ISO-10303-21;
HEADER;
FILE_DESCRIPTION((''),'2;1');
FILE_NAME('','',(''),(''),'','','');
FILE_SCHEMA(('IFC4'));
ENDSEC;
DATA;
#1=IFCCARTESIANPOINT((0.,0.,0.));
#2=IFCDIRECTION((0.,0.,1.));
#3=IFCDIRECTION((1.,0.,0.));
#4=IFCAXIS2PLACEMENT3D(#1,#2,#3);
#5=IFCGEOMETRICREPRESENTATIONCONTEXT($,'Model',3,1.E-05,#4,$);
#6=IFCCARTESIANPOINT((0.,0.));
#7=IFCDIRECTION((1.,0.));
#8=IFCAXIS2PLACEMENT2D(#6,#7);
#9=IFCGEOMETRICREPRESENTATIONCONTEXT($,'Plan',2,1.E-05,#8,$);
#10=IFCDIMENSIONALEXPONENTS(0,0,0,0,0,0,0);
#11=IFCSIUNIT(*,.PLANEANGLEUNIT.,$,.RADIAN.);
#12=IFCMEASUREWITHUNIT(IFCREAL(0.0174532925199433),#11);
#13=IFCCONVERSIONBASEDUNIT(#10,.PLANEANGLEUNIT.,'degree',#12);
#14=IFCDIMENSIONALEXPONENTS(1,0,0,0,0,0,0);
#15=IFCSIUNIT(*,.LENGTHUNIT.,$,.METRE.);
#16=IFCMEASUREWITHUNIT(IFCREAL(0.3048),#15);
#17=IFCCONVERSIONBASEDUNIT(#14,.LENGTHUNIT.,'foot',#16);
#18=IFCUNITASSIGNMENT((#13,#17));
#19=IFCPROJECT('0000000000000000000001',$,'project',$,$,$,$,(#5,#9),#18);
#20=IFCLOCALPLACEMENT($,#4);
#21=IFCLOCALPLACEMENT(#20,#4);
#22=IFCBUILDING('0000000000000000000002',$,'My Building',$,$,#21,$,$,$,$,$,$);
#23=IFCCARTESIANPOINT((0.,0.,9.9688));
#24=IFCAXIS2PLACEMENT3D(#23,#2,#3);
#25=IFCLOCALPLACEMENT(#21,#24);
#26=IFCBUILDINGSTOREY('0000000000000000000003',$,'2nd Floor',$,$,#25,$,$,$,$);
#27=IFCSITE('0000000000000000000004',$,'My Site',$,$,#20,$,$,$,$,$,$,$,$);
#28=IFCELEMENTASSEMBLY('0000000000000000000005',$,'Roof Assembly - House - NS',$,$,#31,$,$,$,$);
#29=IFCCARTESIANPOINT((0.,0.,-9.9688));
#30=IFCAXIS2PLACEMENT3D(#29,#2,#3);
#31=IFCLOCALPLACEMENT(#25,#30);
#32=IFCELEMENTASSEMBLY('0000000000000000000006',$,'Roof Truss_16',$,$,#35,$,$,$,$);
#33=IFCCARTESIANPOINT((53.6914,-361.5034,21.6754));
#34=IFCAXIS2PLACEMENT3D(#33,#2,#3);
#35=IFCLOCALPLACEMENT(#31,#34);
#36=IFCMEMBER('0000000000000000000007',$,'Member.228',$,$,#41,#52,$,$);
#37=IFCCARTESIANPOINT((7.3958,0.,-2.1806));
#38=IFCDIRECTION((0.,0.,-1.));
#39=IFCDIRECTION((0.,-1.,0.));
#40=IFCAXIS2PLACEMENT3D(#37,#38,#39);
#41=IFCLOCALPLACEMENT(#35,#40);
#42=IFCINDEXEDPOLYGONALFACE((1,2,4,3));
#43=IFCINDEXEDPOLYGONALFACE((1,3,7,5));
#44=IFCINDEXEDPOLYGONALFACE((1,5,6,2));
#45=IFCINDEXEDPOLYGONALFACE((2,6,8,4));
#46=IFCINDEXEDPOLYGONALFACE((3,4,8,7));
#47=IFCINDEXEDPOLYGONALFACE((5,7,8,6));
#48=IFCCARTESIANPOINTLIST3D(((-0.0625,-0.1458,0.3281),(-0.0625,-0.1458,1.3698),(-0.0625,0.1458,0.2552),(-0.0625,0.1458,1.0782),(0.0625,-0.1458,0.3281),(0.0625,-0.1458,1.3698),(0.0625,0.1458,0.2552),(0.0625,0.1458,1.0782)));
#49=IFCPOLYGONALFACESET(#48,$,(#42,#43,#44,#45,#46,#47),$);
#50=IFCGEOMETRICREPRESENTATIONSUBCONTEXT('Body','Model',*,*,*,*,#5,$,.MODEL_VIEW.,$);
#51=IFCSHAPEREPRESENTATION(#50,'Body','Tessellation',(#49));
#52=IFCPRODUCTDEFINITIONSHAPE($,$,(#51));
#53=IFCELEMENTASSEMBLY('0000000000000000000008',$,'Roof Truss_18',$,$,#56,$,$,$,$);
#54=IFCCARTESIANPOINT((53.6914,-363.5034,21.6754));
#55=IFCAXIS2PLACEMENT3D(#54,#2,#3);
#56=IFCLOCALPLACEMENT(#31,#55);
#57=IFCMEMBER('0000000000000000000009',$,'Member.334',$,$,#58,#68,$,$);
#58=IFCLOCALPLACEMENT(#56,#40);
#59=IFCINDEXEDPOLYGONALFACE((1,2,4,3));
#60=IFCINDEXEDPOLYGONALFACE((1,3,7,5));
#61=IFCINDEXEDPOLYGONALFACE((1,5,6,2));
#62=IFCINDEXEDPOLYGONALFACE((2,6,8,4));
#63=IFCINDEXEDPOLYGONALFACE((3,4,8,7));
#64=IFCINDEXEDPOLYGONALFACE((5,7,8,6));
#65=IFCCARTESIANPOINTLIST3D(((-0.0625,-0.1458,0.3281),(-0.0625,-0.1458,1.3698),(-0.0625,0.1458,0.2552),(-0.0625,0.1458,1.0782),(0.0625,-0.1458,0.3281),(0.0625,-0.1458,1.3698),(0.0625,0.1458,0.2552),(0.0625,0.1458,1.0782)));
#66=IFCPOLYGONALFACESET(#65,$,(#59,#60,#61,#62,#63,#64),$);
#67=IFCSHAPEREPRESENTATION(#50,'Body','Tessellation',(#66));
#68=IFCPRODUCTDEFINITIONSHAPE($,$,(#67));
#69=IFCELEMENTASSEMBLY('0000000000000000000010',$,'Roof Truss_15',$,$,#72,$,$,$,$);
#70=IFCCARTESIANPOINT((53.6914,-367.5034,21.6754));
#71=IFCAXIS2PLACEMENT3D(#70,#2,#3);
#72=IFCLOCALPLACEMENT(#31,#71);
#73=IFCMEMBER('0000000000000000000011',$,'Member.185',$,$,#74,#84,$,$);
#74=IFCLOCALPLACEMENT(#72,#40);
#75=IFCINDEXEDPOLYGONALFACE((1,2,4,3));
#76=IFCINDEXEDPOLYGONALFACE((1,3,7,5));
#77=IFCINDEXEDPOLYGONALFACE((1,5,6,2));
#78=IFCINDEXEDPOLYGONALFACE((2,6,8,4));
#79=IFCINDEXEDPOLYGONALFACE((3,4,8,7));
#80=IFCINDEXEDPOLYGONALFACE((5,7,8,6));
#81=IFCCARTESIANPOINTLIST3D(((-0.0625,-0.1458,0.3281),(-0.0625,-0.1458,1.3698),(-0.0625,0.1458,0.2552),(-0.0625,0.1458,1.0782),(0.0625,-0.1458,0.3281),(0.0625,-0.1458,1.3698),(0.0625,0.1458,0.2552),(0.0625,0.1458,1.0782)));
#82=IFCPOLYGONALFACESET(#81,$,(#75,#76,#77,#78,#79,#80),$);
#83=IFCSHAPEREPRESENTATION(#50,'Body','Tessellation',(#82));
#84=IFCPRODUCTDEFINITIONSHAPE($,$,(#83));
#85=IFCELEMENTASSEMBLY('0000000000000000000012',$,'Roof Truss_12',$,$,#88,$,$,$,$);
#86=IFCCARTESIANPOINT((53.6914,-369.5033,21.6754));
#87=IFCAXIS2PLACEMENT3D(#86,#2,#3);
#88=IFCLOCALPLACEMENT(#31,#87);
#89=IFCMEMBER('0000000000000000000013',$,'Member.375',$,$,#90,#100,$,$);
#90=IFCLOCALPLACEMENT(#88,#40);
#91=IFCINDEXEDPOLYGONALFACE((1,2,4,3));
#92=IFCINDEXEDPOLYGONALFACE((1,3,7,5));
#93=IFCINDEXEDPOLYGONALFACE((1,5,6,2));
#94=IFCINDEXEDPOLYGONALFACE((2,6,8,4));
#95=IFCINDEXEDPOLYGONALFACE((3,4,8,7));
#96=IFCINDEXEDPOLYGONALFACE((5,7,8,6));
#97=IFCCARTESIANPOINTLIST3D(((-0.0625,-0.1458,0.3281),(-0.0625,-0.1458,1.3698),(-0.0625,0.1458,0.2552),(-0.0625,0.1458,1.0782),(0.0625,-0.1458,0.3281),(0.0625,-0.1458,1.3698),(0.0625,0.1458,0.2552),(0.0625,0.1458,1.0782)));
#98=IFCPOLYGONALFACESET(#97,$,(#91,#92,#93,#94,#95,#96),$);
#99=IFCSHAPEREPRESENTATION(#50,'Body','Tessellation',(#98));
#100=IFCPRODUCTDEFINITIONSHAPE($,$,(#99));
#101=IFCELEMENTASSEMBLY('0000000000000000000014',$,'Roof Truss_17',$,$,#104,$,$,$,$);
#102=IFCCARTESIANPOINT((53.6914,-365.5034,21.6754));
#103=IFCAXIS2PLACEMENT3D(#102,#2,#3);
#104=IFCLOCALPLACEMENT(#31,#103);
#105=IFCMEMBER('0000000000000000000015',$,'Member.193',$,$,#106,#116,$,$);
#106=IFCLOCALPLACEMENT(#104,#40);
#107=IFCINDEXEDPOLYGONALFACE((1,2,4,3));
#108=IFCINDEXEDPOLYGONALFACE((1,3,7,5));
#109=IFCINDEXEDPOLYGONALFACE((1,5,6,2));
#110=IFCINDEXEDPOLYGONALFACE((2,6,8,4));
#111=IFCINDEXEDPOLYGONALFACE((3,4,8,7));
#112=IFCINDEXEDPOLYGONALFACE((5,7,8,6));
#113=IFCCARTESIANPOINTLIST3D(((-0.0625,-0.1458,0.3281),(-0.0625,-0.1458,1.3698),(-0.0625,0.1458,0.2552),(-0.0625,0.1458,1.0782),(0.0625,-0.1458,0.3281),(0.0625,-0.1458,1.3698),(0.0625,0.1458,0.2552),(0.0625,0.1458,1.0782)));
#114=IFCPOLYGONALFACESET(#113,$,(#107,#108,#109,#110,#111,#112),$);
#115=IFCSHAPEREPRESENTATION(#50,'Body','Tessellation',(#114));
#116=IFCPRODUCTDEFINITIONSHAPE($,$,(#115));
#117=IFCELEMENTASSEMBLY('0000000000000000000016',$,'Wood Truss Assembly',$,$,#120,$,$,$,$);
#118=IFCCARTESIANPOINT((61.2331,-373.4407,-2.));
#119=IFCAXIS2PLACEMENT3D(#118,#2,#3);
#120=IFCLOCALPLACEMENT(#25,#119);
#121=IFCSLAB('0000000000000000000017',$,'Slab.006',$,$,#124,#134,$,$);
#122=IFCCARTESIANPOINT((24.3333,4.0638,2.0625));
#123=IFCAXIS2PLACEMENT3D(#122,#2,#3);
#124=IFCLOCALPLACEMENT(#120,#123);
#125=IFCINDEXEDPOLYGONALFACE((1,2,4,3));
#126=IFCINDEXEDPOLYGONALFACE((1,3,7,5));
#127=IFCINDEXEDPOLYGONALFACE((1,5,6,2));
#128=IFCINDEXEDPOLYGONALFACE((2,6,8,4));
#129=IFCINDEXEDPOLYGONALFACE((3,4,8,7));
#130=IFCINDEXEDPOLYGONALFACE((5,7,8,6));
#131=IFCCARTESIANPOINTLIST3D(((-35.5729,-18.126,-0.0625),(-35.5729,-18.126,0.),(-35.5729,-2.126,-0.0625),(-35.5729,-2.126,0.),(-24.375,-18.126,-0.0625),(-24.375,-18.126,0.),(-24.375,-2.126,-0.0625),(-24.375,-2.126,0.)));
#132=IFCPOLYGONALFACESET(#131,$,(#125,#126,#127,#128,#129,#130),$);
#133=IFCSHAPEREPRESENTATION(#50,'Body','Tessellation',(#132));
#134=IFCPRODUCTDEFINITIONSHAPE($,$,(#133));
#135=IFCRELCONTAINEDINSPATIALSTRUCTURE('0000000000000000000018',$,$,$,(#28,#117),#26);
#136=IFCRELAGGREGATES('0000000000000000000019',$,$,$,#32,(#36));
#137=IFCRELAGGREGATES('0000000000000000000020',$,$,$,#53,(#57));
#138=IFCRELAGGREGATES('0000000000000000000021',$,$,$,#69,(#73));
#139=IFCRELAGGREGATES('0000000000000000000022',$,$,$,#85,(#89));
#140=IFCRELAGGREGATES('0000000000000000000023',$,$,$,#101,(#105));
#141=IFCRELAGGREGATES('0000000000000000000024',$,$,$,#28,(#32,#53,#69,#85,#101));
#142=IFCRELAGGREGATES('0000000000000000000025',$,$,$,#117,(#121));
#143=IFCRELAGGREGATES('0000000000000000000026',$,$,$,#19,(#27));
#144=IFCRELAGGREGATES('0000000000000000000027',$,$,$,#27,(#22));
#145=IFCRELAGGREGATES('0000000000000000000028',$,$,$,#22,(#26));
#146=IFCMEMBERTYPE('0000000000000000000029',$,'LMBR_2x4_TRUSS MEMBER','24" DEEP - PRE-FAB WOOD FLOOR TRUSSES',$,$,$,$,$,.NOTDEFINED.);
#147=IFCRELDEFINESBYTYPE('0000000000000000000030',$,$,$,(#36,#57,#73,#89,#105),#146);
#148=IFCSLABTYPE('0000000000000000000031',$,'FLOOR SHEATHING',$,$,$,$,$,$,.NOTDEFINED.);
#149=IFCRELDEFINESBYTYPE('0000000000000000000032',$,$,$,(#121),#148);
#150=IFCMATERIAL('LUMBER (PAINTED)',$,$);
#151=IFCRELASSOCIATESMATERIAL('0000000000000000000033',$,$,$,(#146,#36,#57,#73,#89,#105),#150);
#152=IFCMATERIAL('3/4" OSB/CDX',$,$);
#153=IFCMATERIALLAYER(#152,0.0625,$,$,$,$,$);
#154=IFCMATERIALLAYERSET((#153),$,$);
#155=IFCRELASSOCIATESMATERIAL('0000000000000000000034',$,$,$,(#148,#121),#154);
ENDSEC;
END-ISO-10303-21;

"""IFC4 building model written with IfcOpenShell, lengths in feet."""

from ifc_helpers import new_model, entity, si_unit, converted_unit, frame, origin_with_axes, origin_2d_with_axis, place, context, subcontext, project, spatial, indexed_curve, outline, extrude, clip, halfspace, material, layer, layer_set, layer_usage, material_profile, profile_set, profile_usage, type_object, element, aggregate, save


model = new_model("IFC4")

# Units and contexts
model_context = context("Model", 3, precision=1e-05, world=origin_with_axes())
plan_context = context("Plan", 2, precision=1e-05, world=origin_2d_with_axis())
body_context = subcontext(model_context, "Body", "Model", "MODEL_VIEW")
ifc_project = project(units=[converted_unit("PLANEANGLEUNIT", "degree", entity("IfcReal", 0.0174532925199433), si_unit("PLANEANGLEUNIT", "RADIAN"), dimensions=[0, 0, 0, 0, 0, 0, 0]), converted_unit("LENGTHUNIT", "foot", entity("IfcReal", 0.3048), si_unit("LENGTHUNIT", "METRE"), dimensions=[1, 0, 0, 0, 0, 0, 0])], contexts=[model_context, plan_context])

# Site, building, storey
site_placement = place(None, origin_with_axes())
site = spatial("IfcSite", under=ifc_project, at=site_placement, Name="My Site")
building_placement = place(site_placement, origin_with_axes())
building = spatial("IfcBuilding", under=site, at=building_placement, Name="My Building")
storey_placement = place(building_placement, frame((0.0, 0.0, 9.9688), z_axis=(0.0, 0.0, 1.0), x_axis=(1.0, 0.0, 0.0)))
storey = spatial("IfcBuildingStorey", under=building, at=storey_placement, Name="2nd Floor")

# Shared definitions
ifc_material_1 = material(Name="LUMBER (PAINTED)")

# Element assemblies, members
assembly_1_placement = place(storey_placement, frame((0.0, 0.0, -9.9688), z_axis=(0.0, 0.0, 1.0), x_axis=(1.0, 0.0, 0.0)))
assembly_1 = element("IfcElementAssembly", 1, at=assembly_1_placement, inside=storey, Name="Roof Assembly - House - NS")
assembly_2_placement = place(assembly_1_placement, frame((53.6914, -361.5034, 21.6754), z_axis=(0.0, 0.0, 1.0), x_axis=(1.0, 0.0, 0.0)))
assembly_2 = element("IfcElementAssembly", 2, at=assembly_2_placement, Name="Roof Truss_16")
ifc_material_profile_1 = material_profile(ifc_material_1, outline(indexed_curve([(-0.0625, -0.1458), (0.0625, -0.1458), (0.0625, 0.1458), (-0.0625, 0.1458), (-0.0625, -0.1458)])))
ifc_profile_set_1 = profile_set([ifc_material_profile_1])
member_type_1 = type_object("IfcMemberType", Name="LMBR_2x4_TRUSS MEMBER", Description="24\" DEEP - PRE-FAB WOOD FLOOR TRUSSES", PredefinedType="NOTDEFINED", material=ifc_profile_set_1)
ifc_profile_usage_1 = profile_usage(ifc_profile_set_1)
member_1_placement = place(assembly_2_placement, frame((7.3958, 0.0, -2.1806), z_axis=(0.0, 0.0, -1.0), x_axis=(0.0, -1.0, 0.0)))
member_1 = element("IfcMember", 3, at=member_1_placement, type_object=member_type_1, material=ifc_profile_usage_1, Name="Member.228", context=body_context, shape_type="Clipping", body=[
    clip(clip(extrude(outline(indexed_curve([(-0.0625, -0.1458), (0.0625, -0.1458), (0.0625, 0.1458), (-0.0625, 0.1458), (-0.0625, -0.1458)])), origin_with_axes(), (0.0, 0.0, 1.0), 1.3698), halfspace(frame((0.0, 7.5424, -1.5944), z_axis=(0.0, -0.242599, -0.970127), x_axis=(-1.0, 0.0, 0.0)), False)), halfspace(frame((-397.5032, -0.1458, 1.3698), z_axis=(0.0, 0.707099, 0.707114), x_axis=(1.0, 0.0, 0.0)), False)),
])
aggregate(assembly_2, [member_1])
assembly_3_placement = place(assembly_1_placement, frame((53.6914, -363.5034, 21.6754), z_axis=(0.0, 0.0, 1.0), x_axis=(1.0, 0.0, 0.0)))
assembly_3 = element("IfcElementAssembly", 4, at=assembly_3_placement, Name="Roof Truss_18")
ifc_profile_usage_2 = profile_usage(ifc_profile_set_1)
member_2_placement = place(assembly_3_placement, frame((7.3958, 0.0, -2.1806), z_axis=(0.0, 0.0, -1.0), x_axis=(0.0, -1.0, 0.0)))
member_2 = element("IfcMember", 5, at=member_2_placement, type_object=member_type_1, material=ifc_profile_usage_2, Name="Member.334", context=body_context, shape_type="Clipping", body=[
    clip(clip(extrude(outline(indexed_curve([(-0.0625, -0.1458), (0.0625, -0.1458), (0.0625, 0.1458), (-0.0625, 0.1458), (-0.0625, -0.1458)])), origin_with_axes(), (0.0, 0.0, 1.0), 1.3698), halfspace(frame((0.0, 7.5424, -1.5944), z_axis=(0.0, -0.242599, -0.970127), x_axis=(-1.0, 0.0, 0.0)), False)), halfspace(frame((-397.5032, -0.1458, 1.3698), z_axis=(0.0, 0.707099, 0.707114), x_axis=(1.0, 0.0, 0.0)), False)),
])
aggregate(assembly_3, [member_2])
assembly_4_placement = place(assembly_1_placement, frame((53.6914, -367.5034, 21.6754), z_axis=(0.0, 0.0, 1.0), x_axis=(1.0, 0.0, 0.0)))
assembly_4 = element("IfcElementAssembly", 6, at=assembly_4_placement, Name="Roof Truss_15")
ifc_profile_usage_3 = profile_usage(ifc_profile_set_1)
member_3_placement = place(assembly_4_placement, frame((7.3958, 0.0, -2.1806), z_axis=(0.0, 0.0, -1.0), x_axis=(0.0, -1.0, 0.0)))
member_3 = element("IfcMember", 7, at=member_3_placement, type_object=member_type_1, material=ifc_profile_usage_3, Name="Member.185", context=body_context, shape_type="Clipping", body=[
    clip(clip(extrude(outline(indexed_curve([(-0.0625, -0.1458), (0.0625, -0.1458), (0.0625, 0.1458), (-0.0625, 0.1458), (-0.0625, -0.1458)])), origin_with_axes(), (0.0, 0.0, 1.0), 1.3698), halfspace(frame((0.0, 7.5424, -1.5944), z_axis=(0.0, -0.242599, -0.970127), x_axis=(-1.0, 0.0, 0.0)), False)), halfspace(frame((-397.5032, -0.1458, 1.3698), z_axis=(0.0, 0.707099, 0.707114), x_axis=(1.0, 0.0, 0.0)), False)),
])
aggregate(assembly_4, [member_3])
assembly_5_placement = place(assembly_1_placement, frame((53.6914, -369.5033, 21.6754), z_axis=(0.0, 0.0, 1.0), x_axis=(1.0, 0.0, 0.0)))
assembly_5 = element("IfcElementAssembly", 8, at=assembly_5_placement, Name="Roof Truss_12")
ifc_profile_usage_4 = profile_usage(ifc_profile_set_1)
member_4_placement = place(assembly_5_placement, frame((7.3958, 0.0, -2.1806), z_axis=(0.0, 0.0, -1.0), x_axis=(0.0, -1.0, 0.0)))
member_4 = element("IfcMember", 9, at=member_4_placement, type_object=member_type_1, material=ifc_profile_usage_4, Name="Member.375", context=body_context, shape_type="Clipping", body=[
    clip(clip(extrude(outline(indexed_curve([(-0.0625, -0.1458), (0.0625, -0.1458), (0.0625, 0.1458), (-0.0625, 0.1458), (-0.0625, -0.1458)])), origin_with_axes(), (0.0, 0.0, 1.0), 1.3698), halfspace(frame((0.0, 7.5424, -1.5944), z_axis=(0.0, -0.242599, -0.970127), x_axis=(-1.0, 0.0, 0.0)), False)), halfspace(frame((-397.5032, -0.1458, 1.3698), z_axis=(0.0, 0.707099, 0.707114), x_axis=(1.0, 0.0, 0.0)), False)),
])
aggregate(assembly_5, [member_4])
assembly_6_placement = place(assembly_1_placement, frame((53.6914, -365.5034, 21.6754), z_axis=(0.0, 0.0, 1.0), x_axis=(1.0, 0.0, 0.0)))
assembly_6 = element("IfcElementAssembly", 10, at=assembly_6_placement, Name="Roof Truss_17")
ifc_profile_usage_5 = profile_usage(ifc_profile_set_1)
member_5_placement = place(assembly_6_placement, frame((7.3958, 0.0, -2.1806), z_axis=(0.0, 0.0, -1.0), x_axis=(0.0, -1.0, 0.0)))
member_5 = element("IfcMember", 11, at=member_5_placement, type_object=member_type_1, material=ifc_profile_usage_5, Name="Member.193", context=body_context, shape_type="Clipping", body=[
    clip(clip(extrude(outline(indexed_curve([(-0.0625, -0.1458), (0.0625, -0.1458), (0.0625, 0.1458), (-0.0625, 0.1458), (-0.0625, -0.1458)])), origin_with_axes(), (0.0, 0.0, 1.0), 1.3698), halfspace(frame((0.0, 7.5424, -1.5944), z_axis=(0.0, -0.242599, -0.970127), x_axis=(-1.0, 0.0, 0.0)), False)), halfspace(frame((-397.5032, -0.1458, 1.3698), z_axis=(0.0, 0.707099, 0.707114), x_axis=(1.0, 0.0, 0.0)), False)),
])
aggregate(assembly_6, [member_5])

aggregate(assembly_1, [assembly_2, assembly_3, assembly_4, assembly_5, assembly_6])

# Element assembly, slab
assembly_7_placement = place(storey_placement, frame((61.2331, -373.4407, -2.0), z_axis=(0.0, 0.0, 1.0), x_axis=(1.0, 0.0, 0.0)))
assembly_7 = element("IfcElementAssembly", 12, at=assembly_7_placement, inside=storey, Name="Wood Truss Assembly")
ifc_material_2 = material(Name="3/4\" OSB/CDX")
ifc_layer = layer(ifc_material_2, 0.0625)
ifc_layer_set = layer_set([ifc_layer])
ifc_layer_usage = layer_usage(ifc_layer_set, "AXIS3", "POSITIVE", -0.0625)
slab_type = type_object("IfcSlabType", Name="FLOOR SHEATHING", PredefinedType="NOTDEFINED", material=ifc_layer_set)
slab_placement = place(assembly_7_placement, frame((24.3333, 4.0638, 2.0625), z_axis=(0.0, 0.0, 1.0), x_axis=(1.0, 0.0, 0.0)))
slab = element("IfcSlab", 13, at=slab_placement, type_object=slab_type, material=ifc_layer_usage, Name="Slab.006", context=body_context, shape_type="SweptSolid", body=[
    extrude(outline(indexed_curve([(-35.5729, -18.126), (-24.375, -18.126), (-24.375, -2.126), (-35.5729, -2.126), (-35.5729, -18.126)])), frame((0.0, 0.0, -0.0625), z_axis=(0.0, 0.0, 1.0), x_axis=(1.0, 0.0, 0.0)), (0.0, 0.0, 1.0), 0.0625),
])
aggregate(assembly_7, [slab])

save(model, "model.ifc")
